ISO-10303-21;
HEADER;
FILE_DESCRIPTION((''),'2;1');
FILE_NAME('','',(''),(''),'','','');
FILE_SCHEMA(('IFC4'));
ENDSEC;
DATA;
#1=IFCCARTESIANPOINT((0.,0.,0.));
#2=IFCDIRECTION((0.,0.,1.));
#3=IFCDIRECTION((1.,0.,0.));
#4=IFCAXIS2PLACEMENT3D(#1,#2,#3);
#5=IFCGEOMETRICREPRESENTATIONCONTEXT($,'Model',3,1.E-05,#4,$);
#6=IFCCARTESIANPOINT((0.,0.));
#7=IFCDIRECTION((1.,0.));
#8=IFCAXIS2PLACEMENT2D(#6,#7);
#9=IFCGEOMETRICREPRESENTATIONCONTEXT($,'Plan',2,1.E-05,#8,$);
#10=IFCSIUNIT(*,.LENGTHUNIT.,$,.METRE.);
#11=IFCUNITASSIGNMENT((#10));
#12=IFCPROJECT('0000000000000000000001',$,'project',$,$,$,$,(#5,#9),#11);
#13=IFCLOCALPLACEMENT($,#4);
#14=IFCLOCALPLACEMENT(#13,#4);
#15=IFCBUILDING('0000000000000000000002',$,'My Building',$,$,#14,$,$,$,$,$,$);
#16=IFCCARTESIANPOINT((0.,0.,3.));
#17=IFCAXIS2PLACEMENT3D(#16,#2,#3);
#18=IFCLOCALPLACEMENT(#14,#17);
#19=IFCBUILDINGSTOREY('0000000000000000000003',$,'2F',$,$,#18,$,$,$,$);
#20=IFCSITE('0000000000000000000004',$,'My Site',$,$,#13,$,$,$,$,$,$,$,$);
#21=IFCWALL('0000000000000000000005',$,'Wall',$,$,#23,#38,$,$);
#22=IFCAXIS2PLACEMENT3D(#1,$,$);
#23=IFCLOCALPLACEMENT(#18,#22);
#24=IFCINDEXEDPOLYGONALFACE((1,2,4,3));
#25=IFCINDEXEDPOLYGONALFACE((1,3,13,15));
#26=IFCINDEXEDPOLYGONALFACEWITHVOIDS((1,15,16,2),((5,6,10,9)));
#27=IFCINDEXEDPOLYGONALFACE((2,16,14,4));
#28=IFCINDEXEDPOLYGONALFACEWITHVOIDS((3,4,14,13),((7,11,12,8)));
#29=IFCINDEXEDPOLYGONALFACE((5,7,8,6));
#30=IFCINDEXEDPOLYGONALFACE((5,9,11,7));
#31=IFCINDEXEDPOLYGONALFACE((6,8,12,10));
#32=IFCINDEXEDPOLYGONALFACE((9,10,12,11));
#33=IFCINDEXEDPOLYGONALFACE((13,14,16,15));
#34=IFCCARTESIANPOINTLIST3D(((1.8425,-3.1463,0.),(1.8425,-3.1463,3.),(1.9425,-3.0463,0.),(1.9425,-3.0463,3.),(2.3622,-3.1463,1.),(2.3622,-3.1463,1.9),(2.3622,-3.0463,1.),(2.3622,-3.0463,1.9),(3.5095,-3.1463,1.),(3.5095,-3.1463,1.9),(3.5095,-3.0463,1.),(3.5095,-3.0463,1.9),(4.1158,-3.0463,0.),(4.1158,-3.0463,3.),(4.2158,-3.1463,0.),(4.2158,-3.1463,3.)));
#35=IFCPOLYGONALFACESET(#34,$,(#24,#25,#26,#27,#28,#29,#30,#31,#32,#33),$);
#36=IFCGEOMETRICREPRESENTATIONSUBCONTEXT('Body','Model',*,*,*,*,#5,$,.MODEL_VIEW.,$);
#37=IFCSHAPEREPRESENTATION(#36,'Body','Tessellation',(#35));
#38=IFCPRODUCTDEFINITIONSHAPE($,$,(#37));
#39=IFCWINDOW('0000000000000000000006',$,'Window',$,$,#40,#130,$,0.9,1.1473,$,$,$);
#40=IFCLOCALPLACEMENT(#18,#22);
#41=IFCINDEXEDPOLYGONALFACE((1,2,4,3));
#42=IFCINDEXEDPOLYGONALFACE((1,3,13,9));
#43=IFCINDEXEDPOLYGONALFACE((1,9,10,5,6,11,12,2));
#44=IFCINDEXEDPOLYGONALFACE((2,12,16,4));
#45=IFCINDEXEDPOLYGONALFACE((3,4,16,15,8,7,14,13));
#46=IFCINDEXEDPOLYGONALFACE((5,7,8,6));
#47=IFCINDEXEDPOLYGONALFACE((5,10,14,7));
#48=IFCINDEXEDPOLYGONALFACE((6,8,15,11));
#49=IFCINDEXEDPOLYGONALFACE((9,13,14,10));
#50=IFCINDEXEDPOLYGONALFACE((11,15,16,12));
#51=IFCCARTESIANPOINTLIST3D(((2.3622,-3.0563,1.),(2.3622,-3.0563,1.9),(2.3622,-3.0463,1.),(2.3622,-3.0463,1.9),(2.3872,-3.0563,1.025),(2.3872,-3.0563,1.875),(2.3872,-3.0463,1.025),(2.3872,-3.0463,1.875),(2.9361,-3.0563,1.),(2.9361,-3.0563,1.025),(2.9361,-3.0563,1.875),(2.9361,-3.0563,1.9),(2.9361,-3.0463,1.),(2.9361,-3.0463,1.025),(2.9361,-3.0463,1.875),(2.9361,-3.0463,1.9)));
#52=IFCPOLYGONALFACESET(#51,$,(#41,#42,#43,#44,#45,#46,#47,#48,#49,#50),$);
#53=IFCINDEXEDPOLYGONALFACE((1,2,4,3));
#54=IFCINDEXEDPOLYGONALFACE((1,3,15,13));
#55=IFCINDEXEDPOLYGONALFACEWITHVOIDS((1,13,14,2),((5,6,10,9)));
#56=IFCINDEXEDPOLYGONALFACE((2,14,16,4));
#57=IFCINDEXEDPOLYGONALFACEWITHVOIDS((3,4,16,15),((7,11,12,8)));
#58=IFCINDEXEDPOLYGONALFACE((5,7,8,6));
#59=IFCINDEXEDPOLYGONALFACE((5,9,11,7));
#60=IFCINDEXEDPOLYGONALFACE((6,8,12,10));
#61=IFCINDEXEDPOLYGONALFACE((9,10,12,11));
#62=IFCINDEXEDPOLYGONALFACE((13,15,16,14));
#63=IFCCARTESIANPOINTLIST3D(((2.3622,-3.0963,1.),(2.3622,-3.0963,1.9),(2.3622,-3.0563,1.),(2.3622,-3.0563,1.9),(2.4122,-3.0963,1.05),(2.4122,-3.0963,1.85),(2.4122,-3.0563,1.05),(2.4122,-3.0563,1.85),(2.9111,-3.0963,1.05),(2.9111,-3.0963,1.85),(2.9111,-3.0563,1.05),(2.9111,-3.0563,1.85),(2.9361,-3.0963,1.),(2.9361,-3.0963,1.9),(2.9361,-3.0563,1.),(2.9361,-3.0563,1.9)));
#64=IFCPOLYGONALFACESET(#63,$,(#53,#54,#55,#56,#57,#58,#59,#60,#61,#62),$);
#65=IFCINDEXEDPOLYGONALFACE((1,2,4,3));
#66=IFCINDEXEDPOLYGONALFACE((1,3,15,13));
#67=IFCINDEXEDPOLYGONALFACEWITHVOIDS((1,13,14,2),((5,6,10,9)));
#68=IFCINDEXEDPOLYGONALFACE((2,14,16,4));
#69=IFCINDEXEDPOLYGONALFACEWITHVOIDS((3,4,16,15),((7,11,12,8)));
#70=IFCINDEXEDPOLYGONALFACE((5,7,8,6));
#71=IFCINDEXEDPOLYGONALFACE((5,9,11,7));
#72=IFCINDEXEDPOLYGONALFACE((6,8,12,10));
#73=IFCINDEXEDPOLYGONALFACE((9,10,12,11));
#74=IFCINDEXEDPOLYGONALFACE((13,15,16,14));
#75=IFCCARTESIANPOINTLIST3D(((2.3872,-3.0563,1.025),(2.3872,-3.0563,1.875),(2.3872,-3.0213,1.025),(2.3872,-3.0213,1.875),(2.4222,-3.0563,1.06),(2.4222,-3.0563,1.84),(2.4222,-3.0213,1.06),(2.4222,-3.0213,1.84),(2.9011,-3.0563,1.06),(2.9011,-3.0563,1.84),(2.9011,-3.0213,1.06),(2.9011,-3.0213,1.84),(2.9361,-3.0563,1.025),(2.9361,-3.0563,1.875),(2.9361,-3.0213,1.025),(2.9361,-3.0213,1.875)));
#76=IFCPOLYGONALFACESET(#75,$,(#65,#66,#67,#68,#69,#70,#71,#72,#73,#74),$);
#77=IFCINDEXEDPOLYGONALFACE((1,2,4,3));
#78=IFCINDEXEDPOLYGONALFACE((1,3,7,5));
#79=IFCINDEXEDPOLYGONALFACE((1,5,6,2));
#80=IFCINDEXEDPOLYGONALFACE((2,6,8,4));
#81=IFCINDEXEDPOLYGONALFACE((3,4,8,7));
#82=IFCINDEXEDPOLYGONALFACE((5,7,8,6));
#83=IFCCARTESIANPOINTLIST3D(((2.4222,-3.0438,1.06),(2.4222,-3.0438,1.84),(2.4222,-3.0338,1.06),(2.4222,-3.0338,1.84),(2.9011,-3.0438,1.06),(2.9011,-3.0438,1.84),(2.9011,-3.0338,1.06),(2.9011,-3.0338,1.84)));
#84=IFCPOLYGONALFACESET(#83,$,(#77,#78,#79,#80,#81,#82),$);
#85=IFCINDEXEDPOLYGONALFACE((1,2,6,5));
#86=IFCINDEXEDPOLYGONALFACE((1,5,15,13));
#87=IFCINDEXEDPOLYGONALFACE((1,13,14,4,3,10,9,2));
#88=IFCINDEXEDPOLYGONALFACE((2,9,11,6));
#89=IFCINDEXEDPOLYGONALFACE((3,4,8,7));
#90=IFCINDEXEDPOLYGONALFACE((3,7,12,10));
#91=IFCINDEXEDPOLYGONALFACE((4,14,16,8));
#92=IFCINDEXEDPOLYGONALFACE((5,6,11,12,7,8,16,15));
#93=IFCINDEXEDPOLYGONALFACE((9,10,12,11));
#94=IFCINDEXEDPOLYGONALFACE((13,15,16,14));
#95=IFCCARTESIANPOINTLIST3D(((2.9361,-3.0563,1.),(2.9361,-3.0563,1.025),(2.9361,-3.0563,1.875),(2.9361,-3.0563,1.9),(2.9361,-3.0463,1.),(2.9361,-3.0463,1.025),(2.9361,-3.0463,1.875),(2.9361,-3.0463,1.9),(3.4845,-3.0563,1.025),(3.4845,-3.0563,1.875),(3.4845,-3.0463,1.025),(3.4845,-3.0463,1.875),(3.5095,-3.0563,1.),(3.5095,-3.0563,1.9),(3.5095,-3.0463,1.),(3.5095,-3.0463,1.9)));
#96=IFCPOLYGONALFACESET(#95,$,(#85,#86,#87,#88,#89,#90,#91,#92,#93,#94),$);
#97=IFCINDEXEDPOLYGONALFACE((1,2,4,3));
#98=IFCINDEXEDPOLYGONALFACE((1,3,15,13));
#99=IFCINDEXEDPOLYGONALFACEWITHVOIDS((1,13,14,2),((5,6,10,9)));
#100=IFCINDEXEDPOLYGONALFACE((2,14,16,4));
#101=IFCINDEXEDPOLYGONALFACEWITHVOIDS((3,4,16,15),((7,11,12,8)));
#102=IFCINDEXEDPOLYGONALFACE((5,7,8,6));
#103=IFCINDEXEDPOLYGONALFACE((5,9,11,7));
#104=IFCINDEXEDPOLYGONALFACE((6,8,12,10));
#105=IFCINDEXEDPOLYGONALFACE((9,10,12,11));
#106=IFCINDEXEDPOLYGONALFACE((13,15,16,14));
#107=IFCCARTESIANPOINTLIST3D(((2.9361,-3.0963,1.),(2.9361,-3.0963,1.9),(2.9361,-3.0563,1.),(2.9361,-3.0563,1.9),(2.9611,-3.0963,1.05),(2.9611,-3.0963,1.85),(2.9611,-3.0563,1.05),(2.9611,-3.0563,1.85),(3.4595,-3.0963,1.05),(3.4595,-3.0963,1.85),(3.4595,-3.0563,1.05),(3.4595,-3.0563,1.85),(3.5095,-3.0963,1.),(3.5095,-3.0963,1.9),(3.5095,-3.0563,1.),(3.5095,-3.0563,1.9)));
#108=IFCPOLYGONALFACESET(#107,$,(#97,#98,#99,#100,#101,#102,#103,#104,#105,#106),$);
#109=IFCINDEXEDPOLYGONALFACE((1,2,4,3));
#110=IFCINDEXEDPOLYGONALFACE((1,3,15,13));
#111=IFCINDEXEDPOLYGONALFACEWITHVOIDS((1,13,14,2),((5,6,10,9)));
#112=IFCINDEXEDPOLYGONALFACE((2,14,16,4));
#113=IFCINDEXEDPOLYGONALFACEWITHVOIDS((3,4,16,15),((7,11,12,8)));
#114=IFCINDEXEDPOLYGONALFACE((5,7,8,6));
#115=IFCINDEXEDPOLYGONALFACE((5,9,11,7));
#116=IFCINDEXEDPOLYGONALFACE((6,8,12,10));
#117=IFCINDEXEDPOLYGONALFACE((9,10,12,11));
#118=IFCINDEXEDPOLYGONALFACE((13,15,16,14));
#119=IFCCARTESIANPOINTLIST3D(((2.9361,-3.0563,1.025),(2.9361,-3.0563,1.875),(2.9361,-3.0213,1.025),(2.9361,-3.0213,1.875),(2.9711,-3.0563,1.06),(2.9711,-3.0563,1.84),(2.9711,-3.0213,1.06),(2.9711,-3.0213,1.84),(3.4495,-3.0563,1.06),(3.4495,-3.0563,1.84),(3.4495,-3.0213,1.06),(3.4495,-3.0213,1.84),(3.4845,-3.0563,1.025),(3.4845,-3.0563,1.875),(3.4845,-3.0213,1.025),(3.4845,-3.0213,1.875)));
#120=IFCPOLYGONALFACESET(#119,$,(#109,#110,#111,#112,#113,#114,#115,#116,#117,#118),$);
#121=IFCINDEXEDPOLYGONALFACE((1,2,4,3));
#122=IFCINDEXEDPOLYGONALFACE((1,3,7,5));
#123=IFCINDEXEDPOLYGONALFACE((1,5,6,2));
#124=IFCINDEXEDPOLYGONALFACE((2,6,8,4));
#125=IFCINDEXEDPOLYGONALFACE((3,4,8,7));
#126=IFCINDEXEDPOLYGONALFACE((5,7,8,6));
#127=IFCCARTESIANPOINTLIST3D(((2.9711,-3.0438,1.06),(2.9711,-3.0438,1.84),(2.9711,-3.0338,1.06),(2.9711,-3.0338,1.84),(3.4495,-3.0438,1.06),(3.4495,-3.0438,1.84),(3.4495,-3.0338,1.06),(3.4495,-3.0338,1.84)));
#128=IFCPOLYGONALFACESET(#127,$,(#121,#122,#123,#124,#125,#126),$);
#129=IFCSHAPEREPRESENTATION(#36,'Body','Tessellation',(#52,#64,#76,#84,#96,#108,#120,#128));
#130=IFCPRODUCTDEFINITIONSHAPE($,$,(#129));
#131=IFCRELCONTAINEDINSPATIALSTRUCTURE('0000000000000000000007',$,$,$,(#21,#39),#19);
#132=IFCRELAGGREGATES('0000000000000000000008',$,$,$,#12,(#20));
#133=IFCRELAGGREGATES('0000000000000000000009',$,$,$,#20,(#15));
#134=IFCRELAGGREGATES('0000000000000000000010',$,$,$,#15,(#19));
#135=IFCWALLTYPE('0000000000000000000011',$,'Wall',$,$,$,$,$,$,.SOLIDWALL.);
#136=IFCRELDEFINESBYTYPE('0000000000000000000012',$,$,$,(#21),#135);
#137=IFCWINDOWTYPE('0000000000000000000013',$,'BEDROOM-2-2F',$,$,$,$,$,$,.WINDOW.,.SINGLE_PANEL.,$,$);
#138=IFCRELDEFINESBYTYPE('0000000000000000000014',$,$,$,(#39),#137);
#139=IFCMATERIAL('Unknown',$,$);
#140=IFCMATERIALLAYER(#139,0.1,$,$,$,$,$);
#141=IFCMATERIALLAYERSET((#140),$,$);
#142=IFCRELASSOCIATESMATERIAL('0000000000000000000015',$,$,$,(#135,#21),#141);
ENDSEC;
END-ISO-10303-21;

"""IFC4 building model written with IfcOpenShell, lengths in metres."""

from ifc_helpers import new_model, entity, si_unit, frame, origin_with_axes, origin_2d_with_axis, place, context, subcontext, project, spatial, line, indexed_curve, outline, extrude, shape, source, transform, mapped, material, layer, layer_set, layer_usage, type_object, type_shapes, element, fill, save


model = new_model("IFC4")

# Units and contexts
model_context = context("Model", 3, precision=1e-05, world=origin_with_axes())
plan_context = context("Plan", 2, precision=1e-05, world=origin_2d_with_axis())
body_context_1 = subcontext(model_context, "Body", "Model", "MODEL_VIEW")
body_context_2 = subcontext(plan_context, "Body", "Plan", "PLAN_VIEW")
ifc_project = project(units=[si_unit("LENGTHUNIT", "METRE")], contexts=[model_context, plan_context])

# Site, building, storey
site_placement = place(None, origin_with_axes())
site = spatial("IfcSite", under=ifc_project, at=site_placement, Name="My Site")
building_placement = place(site_placement, origin_with_axes())
building = spatial("IfcBuilding", under=site, at=building_placement, Name="My Building")
storey_placement = place(building_placement, frame((0.0, 0.0, 3.0), z_axis=(0.0, 0.0, 1.0), x_axis=(1.0, 0.0, 0.0)))
storey = spatial("IfcBuildingStorey", under=building, at=storey_placement, Name="2F")

# Shared definitions
ifc_material_1 = material(Name="Unknown")

# Shared definitions
ifc_layer_1 = layer(ifc_material_1, 0.1)
ifc_layer_set_1 = layer_set([ifc_layer_1])
wall_type = type_object("IfcWallType", Name="Wall", PredefinedType="SOLIDWALL", material=ifc_layer_set_1)

# Wall, opening, window
ifc_layer_usage_1 = layer_usage(ifc_layer_set_1, "AXIS2", "POSITIVE", 0.0)
wall_1_placement = place(storey_placement, frame((1.8425, -3.1463, 0.0), z_axis=(0.0, 0.0, 1.0), x_axis=(1.0, 0.0, 0.0)))
wall_1 = element("IfcWall", 1, at=wall_1_placement, inside=storey, type_object=wall_type, material=ifc_layer_usage_1, Name="Wall", context=body_context_1, shape_type="SweptSolid", body=[
    extrude(outline(indexed_curve([(0.0, 0.0), (0.1, 0.1), (2.2734, 0.1), (2.3734, 0.0)], segments=[line(1, 2, 3, 4, 1)])), origin_with_axes(), (0.0, 0.0, 1.0), 3.0),
])
shared_shape_1 = source(origin_with_axes(), body_context_1, "Body", "SweptSolid", [
    extrude(outline(indexed_curve([(0.0, 0.0), (1.1473, 0.0), (1.1473, 0.9), (0.0, 0.9)], segments=[line(1, 2, 3, 4, 1)])), frame((0.0, -0.6, 0.0), z_axis=(0.0, -1.0, 0.0), x_axis=(1.0, 0.0, 0.0)), (0.0, 0.0, -1.0), 1.2),
])
opening_1_placement = place(wall_1_placement, frame((0.5197, 0.0, 1.0), z_axis=(0.0, 0.0, 1.0), x_axis=(1.0, 0.0, 0.0)))
opening_1 = element("IfcOpeningElement", 2, at=opening_1_placement, cuts=wall_1, PredefinedType="OPENING", context=body_context_1, shape_type="MappedRepresentation", body=[
    mapped(shared_shape_1, transform((0.0, 0.0, 0.0), x_axis=(1.0, 0.0, 0.0), y_axis=(0.0, 1.0, 0.0), z_axis=(0.0, 0.0, 1.0), scale=1.0)),
])
window_type = type_object("IfcWindowType", Name="BEDROOM-2-2F", PartitioningType="SINGLE_PANEL", PredefinedType="WINDOW")
shared_shape_2 = source(origin_with_axes(), body_context_1, "Body", "SweptSolid", [
    extrude(outline(indexed_curve([(0.5739, 0.0), (0.0, 0.0), (0.0, 0.9), (0.5739, 0.9), (0.5739, 0.875), (0.025, 0.875), (0.025, 0.025), (0.5739, 0.025)], segments=[line(1, 2, 3, 4, 5, 6, 7, 8, 1)])), frame((0.0, 0.09, 0.0), z_axis=(0.0, -1.0, 0.0), x_axis=(1.0, 0.0, 0.0)), (0.0, 0.0, -1.0), 0.01),
    extrude(outline(indexed_curve([(0.0, 0.0), (0.5739, 0.0), (0.5739, 0.9), (0.0, 0.9)], segments=[line(1, 2, 3, 4, 1)]), holes=[indexed_curve([(0.05, 0.05), (0.5489, 0.05), (0.5489, 0.85), (0.05, 0.85)], segments=[line(1, 2, 3, 4, 1)])]), frame((0.0, 0.05, 0.0), z_axis=(0.0, -1.0, 0.0), x_axis=(1.0, 0.0, 0.0)), (0.0, 0.0, -1.0), 0.04),
    extrude(outline(indexed_curve([(0.0, 0.0), (0.5489, 0.0), (0.5489, 0.85), (0.0, 0.85)], segments=[line(1, 2, 3, 4, 1)]), holes=[indexed_curve([(0.035, 0.035), (0.5139, 0.035), (0.5139, 0.815), (0.035, 0.815)], segments=[line(1, 2, 3, 4, 1)])]), frame((0.025, 0.09, 0.025), z_axis=(0.0, -1.0, 0.0), x_axis=(1.0, 0.0, 0.0)), (0.0, 0.0, -1.0), 0.035),
    extrude(outline(indexed_curve([(0.035, 0.035), (0.5139, 0.035), (0.5139, 0.815), (0.035, 0.815)], segments=[line(1, 2, 3, 4, 1)])), frame((0.025, 0.1025, 0.025), z_axis=(0.0, -1.0, 0.0), x_axis=(1.0, 0.0, 0.0)), (0.0, 0.0, -1.0), 0.01),
    extrude(outline(indexed_curve([(0.0, 0.9), (0.5733, 0.9), (0.5733, 0.0), (0.0, 0.0), (0.0, 0.025), (0.5483, 0.025), (0.5483, 0.875), (0.0, 0.875)], segments=[line(1, 2, 3, 4, 5, 6, 7, 8, 1)])), frame((0.5739, 0.09, 0.0), z_axis=(0.0, -1.0, 0.0), x_axis=(1.0, 0.0, 0.0)), (0.0, 0.0, -1.0), 0.01),
    extrude(outline(indexed_curve([(0.0, 0.0), (0.5733, 0.0), (0.5733, 0.9), (0.0, 0.9)], segments=[line(1, 2, 3, 4, 1)]), holes=[indexed_curve([(0.025, 0.05), (0.5233, 0.05), (0.5233, 0.85), (0.025, 0.85)], segments=[line(1, 2, 3, 4, 1)])]), frame((0.5739, 0.05, 0.0), z_axis=(0.0, -1.0, 0.0), x_axis=(1.0, 0.0, 0.0)), (0.0, 0.0, -1.0), 0.04),
    extrude(outline(indexed_curve([(0.0, 0.0), (0.5483, 0.0), (0.5483, 0.85), (0.0, 0.85)], segments=[line(1, 2, 3, 4, 1)]), holes=[indexed_curve([(0.035, 0.035), (0.5133, 0.035), (0.5133, 0.815), (0.035, 0.815)], segments=[line(1, 2, 3, 4, 1)])]), frame((0.5739, 0.09, 0.025), z_axis=(0.0, -1.0, 0.0), x_axis=(1.0, 0.0, 0.0)), (0.0, 0.0, -1.0), 0.035),
    extrude(outline(indexed_curve([(0.035, 0.035), (0.5133, 0.035), (0.5133, 0.815), (0.035, 0.815)], segments=[line(1, 2, 3, 4, 1)])), frame((0.5739, 0.1025, 0.025), z_axis=(0.0, -1.0, 0.0), x_axis=(1.0, 0.0, 0.0)), (0.0, 0.0, -1.0), 0.01),
])
shared_shape_3 = source(origin_with_axes(), body_context_2, "Body", "Curve2D", [
    entity("IfcIndexedPolyCurve", entity("IfcCartesianPointList2D", [[0.05, 0.05], [0.5489, 0.05]])),
    entity("IfcIndexedPolyCurve", entity("IfcCartesianPointList2D", [[0.0, 0.1], [0.025, 0.1], [0.025, 0.09], [0.05, 0.09], [0.05, 0.05], [0.0, 0.05]]), [entity("IfcLineIndex", [1, 2, 3, 4, 5, 6, 1])]),
    entity("IfcIndexedPolyCurve", entity("IfcCartesianPointList2D", [[0.5739, 0.1], [0.5739, 0.1], [0.5739, 0.09], [0.5489, 0.09], [0.5489, 0.05], [0.5739, 0.05]])),
    entity("IfcIndexedPolyCurve", entity("IfcCartesianPointList2D", [[0.025, 0.09], [0.06, 0.09], [0.06, 0.125], [0.025, 0.125]]), [entity("IfcLineIndex", [1, 2, 3, 4, 1])]),
    entity("IfcIndexedPolyCurve", entity("IfcCartesianPointList2D", [[0.5739, 0.09], [0.5389, 0.09], [0.5389, 0.125], [0.5739, 0.125]]), [entity("IfcLineIndex", [1, 2, 3, 4, 1])]),
    entity("IfcIndexedPolyCurve", entity("IfcCartesianPointList2D", [[0.06, 0.09], [0.5389, 0.09]])),
    entity("IfcIndexedPolyCurve", entity("IfcCartesianPointList2D", [[0.06, 0.125], [0.5389, 0.125]])),
    entity("IfcIndexedPolyCurve", entity("IfcCartesianPointList2D", [[0.06, 0.1075], [0.5389, 0.1075]])),
    entity("IfcIndexedPolyCurve", entity("IfcCartesianPointList2D", [[0.5989, 0.05], [1.0973, 0.05]])),
    entity("IfcIndexedPolyCurve", entity("IfcCartesianPointList2D", [[0.5739, 0.1], [0.5739, 0.1], [0.5739, 0.09], [0.5989, 0.09], [0.5989, 0.05], [0.5739, 0.05]])),
    entity("IfcIndexedPolyCurve", entity("IfcCartesianPointList2D", [[1.1473, 0.1], [1.1223, 0.1], [1.1223, 0.09], [1.0973, 0.09], [1.0973, 0.05], [1.1473, 0.05]]), [entity("IfcLineIndex", [1, 2, 3, 4, 5, 6, 1])]),
    entity("IfcIndexedPolyCurve", entity("IfcCartesianPointList2D", [[0.5739, 0.09], [0.6089, 0.09], [0.6089, 0.125], [0.5739, 0.125]]), [entity("IfcLineIndex", [1, 2, 3, 4, 1])]),
    entity("IfcIndexedPolyCurve", entity("IfcCartesianPointList2D", [[1.1223, 0.09], [1.0873, 0.09], [1.0873, 0.125], [1.1223, 0.125]]), [entity("IfcLineIndex", [1, 2, 3, 4, 1])]),
    entity("IfcIndexedPolyCurve", entity("IfcCartesianPointList2D", [[0.6089, 0.09], [1.0873, 0.09]])),
    entity("IfcIndexedPolyCurve", entity("IfcCartesianPointList2D", [[0.6089, 0.125], [1.0873, 0.125]])),
    entity("IfcIndexedPolyCurve", entity("IfcCartesianPointList2D", [[0.6089, 0.1075], [1.0873, 0.1075]])),
])
type_shapes(window_type, [shared_shape_2, shared_shape_3])
window_placement = place(opening_1_placement, origin_with_axes())
window = element("IfcWindow", 3, at=window_placement, inside=storey, type_object=window_type, Name="Window", OverallHeight=0.9, OverallWidth=1.1473, shapes=[
    shape(body_context_1, "Body", "MappedRepresentation", [mapped(shared_shape_2, transform((0.0, 0.0, 0.0), x_axis=(1.0, 0.0, 0.0), y_axis=(0.0, 1.0, 0.0), z_axis=(0.0, 0.0, 1.0), scale=1.0))]),
    shape(body_context_2, "Body", "MappedRepresentation", [mapped(shared_shape_3, transform((0.0, 0.0, 0.0), x_axis=(1.0, 0.0, 0.0), y_axis=(0.0, 1.0, 0.0), z_axis=(0.0, 0.0, 1.0), scale=1.0))]),
])
fill(opening_1, window)

save(model, "model.ifc")
